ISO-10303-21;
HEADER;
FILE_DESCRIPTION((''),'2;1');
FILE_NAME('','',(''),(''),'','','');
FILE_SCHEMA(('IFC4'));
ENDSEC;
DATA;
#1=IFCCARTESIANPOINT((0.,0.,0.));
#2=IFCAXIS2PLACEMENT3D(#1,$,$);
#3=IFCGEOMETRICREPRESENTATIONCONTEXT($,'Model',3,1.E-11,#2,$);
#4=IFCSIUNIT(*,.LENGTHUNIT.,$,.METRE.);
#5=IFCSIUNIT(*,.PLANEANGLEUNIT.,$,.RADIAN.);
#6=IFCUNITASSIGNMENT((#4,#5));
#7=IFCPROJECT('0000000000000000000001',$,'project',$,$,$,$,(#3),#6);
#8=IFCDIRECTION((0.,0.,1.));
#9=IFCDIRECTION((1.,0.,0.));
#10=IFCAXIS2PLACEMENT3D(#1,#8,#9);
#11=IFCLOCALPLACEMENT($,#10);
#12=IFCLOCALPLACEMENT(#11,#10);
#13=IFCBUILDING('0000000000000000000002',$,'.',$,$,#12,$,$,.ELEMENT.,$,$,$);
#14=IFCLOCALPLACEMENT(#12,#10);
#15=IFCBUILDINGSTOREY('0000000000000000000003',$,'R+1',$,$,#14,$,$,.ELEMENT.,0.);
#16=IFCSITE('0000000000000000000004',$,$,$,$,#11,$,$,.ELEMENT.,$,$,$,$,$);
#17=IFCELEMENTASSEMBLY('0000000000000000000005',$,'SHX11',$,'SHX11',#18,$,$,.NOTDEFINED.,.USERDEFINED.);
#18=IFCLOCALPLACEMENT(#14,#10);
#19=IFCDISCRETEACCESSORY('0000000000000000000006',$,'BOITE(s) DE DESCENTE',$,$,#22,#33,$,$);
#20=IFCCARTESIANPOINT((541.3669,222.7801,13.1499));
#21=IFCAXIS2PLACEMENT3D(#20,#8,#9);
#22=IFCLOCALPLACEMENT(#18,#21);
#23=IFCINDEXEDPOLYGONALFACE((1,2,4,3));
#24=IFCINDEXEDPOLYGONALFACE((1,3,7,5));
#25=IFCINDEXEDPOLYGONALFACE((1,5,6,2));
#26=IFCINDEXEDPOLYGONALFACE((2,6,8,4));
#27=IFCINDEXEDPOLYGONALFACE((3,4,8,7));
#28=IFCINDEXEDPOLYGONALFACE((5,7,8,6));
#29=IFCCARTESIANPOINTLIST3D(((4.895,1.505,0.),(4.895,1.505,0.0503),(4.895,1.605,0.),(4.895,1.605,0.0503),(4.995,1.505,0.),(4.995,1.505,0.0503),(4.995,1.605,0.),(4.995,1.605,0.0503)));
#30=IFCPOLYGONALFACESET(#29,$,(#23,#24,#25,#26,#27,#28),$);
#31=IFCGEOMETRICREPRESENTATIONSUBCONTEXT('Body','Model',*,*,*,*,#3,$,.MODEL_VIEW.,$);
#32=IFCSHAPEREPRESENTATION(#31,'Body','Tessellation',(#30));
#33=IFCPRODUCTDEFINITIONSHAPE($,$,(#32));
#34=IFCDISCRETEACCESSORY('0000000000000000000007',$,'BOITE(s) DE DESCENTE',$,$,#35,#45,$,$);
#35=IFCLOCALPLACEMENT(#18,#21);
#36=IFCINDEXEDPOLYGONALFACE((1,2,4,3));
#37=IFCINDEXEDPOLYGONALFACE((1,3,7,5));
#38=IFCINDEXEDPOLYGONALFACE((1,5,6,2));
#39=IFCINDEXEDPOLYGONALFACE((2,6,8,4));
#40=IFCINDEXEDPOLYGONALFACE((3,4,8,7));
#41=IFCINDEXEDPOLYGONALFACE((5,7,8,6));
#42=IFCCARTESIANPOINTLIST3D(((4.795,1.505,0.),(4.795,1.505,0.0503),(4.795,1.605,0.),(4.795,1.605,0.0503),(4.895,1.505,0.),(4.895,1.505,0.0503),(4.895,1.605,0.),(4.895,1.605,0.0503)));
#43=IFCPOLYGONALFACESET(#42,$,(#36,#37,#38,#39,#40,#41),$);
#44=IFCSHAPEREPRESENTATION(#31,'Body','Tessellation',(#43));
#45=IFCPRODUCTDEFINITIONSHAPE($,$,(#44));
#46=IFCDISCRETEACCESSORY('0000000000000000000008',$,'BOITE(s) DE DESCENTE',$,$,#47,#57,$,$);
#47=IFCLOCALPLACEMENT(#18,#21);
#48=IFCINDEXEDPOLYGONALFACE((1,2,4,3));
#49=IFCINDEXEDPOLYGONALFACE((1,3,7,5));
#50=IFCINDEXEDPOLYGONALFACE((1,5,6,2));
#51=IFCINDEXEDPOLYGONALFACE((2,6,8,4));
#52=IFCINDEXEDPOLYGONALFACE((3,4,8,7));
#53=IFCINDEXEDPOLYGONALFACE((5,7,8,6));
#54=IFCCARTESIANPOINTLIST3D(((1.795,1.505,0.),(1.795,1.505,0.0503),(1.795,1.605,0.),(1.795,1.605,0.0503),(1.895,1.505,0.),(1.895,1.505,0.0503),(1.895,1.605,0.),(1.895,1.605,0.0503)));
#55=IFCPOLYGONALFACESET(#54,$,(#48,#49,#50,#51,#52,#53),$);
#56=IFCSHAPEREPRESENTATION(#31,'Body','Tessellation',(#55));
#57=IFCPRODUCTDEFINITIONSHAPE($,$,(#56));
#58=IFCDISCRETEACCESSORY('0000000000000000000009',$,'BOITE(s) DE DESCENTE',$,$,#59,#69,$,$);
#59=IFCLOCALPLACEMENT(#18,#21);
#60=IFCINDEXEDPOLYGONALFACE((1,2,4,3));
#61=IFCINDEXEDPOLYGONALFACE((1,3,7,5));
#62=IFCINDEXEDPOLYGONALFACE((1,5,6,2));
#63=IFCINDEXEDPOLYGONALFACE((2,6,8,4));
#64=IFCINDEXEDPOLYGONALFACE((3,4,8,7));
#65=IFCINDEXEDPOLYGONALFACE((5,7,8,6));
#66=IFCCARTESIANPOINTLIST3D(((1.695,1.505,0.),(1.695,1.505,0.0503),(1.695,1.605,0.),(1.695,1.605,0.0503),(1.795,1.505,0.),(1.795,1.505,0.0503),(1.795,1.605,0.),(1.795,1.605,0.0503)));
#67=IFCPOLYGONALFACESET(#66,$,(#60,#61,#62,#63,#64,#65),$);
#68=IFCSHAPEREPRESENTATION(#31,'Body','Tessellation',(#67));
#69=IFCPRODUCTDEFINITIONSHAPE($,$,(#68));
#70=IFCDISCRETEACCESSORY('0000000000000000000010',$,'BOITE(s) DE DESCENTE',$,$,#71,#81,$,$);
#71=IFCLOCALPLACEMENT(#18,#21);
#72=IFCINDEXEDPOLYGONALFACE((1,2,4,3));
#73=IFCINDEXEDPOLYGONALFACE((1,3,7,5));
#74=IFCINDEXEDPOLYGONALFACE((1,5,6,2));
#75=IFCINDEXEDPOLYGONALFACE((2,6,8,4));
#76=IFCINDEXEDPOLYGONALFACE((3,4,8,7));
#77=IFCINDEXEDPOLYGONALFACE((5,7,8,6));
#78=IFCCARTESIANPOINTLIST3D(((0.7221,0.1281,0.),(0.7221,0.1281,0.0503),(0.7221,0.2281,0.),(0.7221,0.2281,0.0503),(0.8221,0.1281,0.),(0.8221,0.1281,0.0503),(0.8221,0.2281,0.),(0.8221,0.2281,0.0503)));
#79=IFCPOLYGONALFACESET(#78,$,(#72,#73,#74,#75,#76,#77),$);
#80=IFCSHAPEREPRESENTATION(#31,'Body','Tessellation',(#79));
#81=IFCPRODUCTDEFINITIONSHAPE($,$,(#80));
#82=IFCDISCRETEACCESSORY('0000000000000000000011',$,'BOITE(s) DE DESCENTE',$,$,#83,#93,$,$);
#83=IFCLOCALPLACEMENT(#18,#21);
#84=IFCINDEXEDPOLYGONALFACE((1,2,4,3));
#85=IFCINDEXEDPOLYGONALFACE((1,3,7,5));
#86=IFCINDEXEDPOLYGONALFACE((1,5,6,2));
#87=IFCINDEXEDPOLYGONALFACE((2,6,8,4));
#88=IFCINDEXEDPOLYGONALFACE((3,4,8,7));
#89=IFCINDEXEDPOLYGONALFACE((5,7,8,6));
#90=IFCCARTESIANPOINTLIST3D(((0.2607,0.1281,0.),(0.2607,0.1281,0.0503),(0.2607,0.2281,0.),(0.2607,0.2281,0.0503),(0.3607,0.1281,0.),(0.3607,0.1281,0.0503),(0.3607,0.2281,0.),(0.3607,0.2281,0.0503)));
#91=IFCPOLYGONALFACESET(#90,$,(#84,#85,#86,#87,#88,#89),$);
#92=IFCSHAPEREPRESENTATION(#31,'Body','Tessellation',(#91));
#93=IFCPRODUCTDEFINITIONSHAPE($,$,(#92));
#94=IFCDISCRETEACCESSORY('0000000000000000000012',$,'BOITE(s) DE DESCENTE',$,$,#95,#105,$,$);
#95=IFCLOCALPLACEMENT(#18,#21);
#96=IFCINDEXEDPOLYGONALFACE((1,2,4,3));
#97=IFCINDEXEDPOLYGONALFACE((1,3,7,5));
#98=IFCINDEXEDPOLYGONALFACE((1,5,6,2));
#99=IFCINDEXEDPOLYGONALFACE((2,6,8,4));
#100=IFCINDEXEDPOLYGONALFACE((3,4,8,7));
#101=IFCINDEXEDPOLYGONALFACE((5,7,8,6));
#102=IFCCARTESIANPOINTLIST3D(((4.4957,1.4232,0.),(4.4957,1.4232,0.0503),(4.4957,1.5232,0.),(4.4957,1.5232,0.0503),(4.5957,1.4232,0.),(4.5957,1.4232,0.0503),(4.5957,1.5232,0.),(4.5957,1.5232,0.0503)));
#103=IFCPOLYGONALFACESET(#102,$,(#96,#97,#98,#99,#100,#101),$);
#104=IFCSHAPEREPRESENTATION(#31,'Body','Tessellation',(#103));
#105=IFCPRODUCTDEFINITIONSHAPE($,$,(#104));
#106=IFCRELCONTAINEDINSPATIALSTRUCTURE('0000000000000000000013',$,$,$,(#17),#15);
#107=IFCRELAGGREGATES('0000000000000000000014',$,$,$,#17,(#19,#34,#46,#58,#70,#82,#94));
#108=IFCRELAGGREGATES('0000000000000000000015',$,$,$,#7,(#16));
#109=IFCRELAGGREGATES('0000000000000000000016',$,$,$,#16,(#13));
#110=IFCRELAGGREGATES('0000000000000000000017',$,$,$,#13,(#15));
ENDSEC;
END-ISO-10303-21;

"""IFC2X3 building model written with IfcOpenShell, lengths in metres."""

from ifc_helpers import new_model, si_unit, frame, origin, origin_with_axes, place, context, subcontext, project, spatial, polyline, outline, extrude, element, aggregate, save


model = new_model("IFC2X3")

# Units and contexts
model_context = context("Model", 3, precision=1e-11, world=origin())
body_context = subcontext(model_context, "Body", "Model", "MODEL_VIEW")
ifc_project = project(units=[si_unit("LENGTHUNIT", "METRE"), si_unit("PLANEANGLEUNIT", "RADIAN")], contexts=[model_context])

# Site, building, storey
site_placement = place(None, origin_with_axes())
site = spatial("IfcSite", under=ifc_project, at=site_placement, CompositionType="ELEMENT")
building_placement = place(site_placement, origin_with_axes())
building = spatial("IfcBuilding", under=site, at=building_placement, Name=".", CompositionType="ELEMENT")
storey_placement = place(building_placement, origin_with_axes())
storey = spatial("IfcBuildingStorey", under=building, at=storey_placement, Name="R+1", CompositionType="ELEMENT", Elevation=0.0)

# Element assembly, discrete accessories
assembly_placement = place(storey_placement, origin_with_axes())
assembly = element("IfcElementAssembly", 1, at=assembly_placement, inside=storey, Name="SHX11", ObjectType="SHX11", AssemblyPlace="NOTDEFINED", PredefinedType="USERDEFINED")
discrete_accessory_1_placement = place(assembly_placement, frame((541.3669, 222.7801, 13.1499), z_axis=(0.0, 0.0, 1.0), x_axis=(1.0, 0.0, 0.0)))
discrete_accessory_1 = element("IfcDiscreteAccessory", 2, at=discrete_accessory_1_placement, Name="BOITE(s) DE DESCENTE", context=body_context, shape_type="SweptSolid", body=[
    extrude(outline(polyline([(1.505, -4.895), (1.505, -4.995), (1.605, -4.995), (1.605, -4.895), (1.505, -4.895)])), frame((0.0, 0.0, 0.0), z_axis=(0.0, 0.0, 1.0), x_axis=(0.0, 1.0, 0.0)), (0.0, 0.0, 1.0), 0.0503),
])
discrete_accessory_2_placement = place(assembly_placement, frame((541.3669, 222.7801, 13.1499), z_axis=(0.0, 0.0, 1.0), x_axis=(1.0, 0.0, 0.0)))
discrete_accessory_2 = element("IfcDiscreteAccessory", 3, at=discrete_accessory_2_placement, Name="BOITE(s) DE DESCENTE", context=body_context, shape_type="SweptSolid", body=[
    extrude(outline(polyline([(1.505, -4.795), (1.505, -4.895), (1.605, -4.895), (1.605, -4.795), (1.505, -4.795)])), frame((0.0, 0.0, 0.0), z_axis=(0.0, 0.0, 1.0), x_axis=(0.0, 1.0, 0.0)), (0.0, 0.0, 1.0), 0.0503),
])
discrete_accessory_3_placement = place(assembly_placement, frame((541.3669, 222.7801, 13.1499), z_axis=(0.0, 0.0, 1.0), x_axis=(1.0, 0.0, 0.0)))
discrete_accessory_3 = element("IfcDiscreteAccessory", 4, at=discrete_accessory_3_placement, Name="BOITE(s) DE DESCENTE", context=body_context, shape_type="SweptSolid", body=[
    extrude(outline(polyline([(1.505, -1.795), (1.505, -1.895), (1.605, -1.895), (1.605, -1.795), (1.505, -1.795)])), frame((0.0, 0.0, 0.0), z_axis=(0.0, 0.0, 1.0), x_axis=(0.0, 1.0, 0.0)), (0.0, 0.0, 1.0), 0.0503),
])
discrete_accessory_4_placement = place(assembly_placement, frame((541.3669, 222.7801, 13.1499), z_axis=(0.0, 0.0, 1.0), x_axis=(1.0, 0.0, 0.0)))
discrete_accessory_4 = element("IfcDiscreteAccessory", 5, at=discrete_accessory_4_placement, Name="BOITE(s) DE DESCENTE", context=body_context, shape_type="SweptSolid", body=[
    extrude(outline(polyline([(1.505, -1.695), (1.505, -1.795), (1.605, -1.795), (1.605, -1.695), (1.505, -1.695)])), frame((0.0, 0.0, 0.0), z_axis=(0.0, 0.0, 1.0), x_axis=(0.0, 1.0, 0.0)), (0.0, 0.0, 1.0), 0.0503),
])
discrete_accessory_5_placement = place(assembly_placement, frame((541.3669, 222.7801, 13.1499), z_axis=(0.0, 0.0, 1.0), x_axis=(1.0, 0.0, 0.0)))
discrete_accessory_5 = element("IfcDiscreteAccessory", 6, at=discrete_accessory_5_placement, Name="BOITE(s) DE DESCENTE", context=body_context, shape_type="SweptSolid", body=[
    extrude(outline(polyline([(0.1281, -0.7221), (0.1281, -0.8221), (0.2281, -0.8221), (0.2281, -0.7221), (0.1281, -0.7221)])), frame((0.0, 0.0, 0.0), z_axis=(0.0, 0.0, 1.0), x_axis=(0.0, 1.0, 0.0)), (0.0, 0.0, 1.0), 0.0503),
])
discrete_accessory_6_placement = place(assembly_placement, frame((541.3669, 222.7801, 13.1499), z_axis=(0.0, 0.0, 1.0), x_axis=(1.0, 0.0, 0.0)))
discrete_accessory_6 = element("IfcDiscreteAccessory", 7, at=discrete_accessory_6_placement, Name="BOITE(s) DE DESCENTE", context=body_context, shape_type="SweptSolid", body=[
    extrude(outline(polyline([(0.1281, -0.2607), (0.1281, -0.3607), (0.2281, -0.3607), (0.2281, -0.2607), (0.1281, -0.2607)])), frame((0.0, 0.0, 0.0), z_axis=(0.0, 0.0, 1.0), x_axis=(0.0, 1.0, 0.0)), (0.0, 0.0, 1.0), 0.0503),
])
discrete_accessory_7_placement = place(assembly_placement, frame((541.3669, 222.7801, 13.1499), z_axis=(0.0, 0.0, 1.0), x_axis=(1.0, 0.0, 0.0)))
discrete_accessory_7 = element("IfcDiscreteAccessory", 8, at=discrete_accessory_7_placement, Name="BOITE(s) DE DESCENTE", context=body_context, shape_type="SweptSolid", body=[
    extrude(outline(polyline([(1.4232, -4.4957), (1.4232, -4.5957), (1.5232, -4.5957), (1.5232, -4.4957), (1.4232, -4.4957)])), frame((0.0, 0.0, 0.0), z_axis=(0.0, 0.0, 1.0), x_axis=(0.0, 1.0, 0.0)), (0.0, 0.0, 1.0), 0.0503),
])
aggregate(assembly, [discrete_accessory_1, discrete_accessory_2, discrete_accessory_3, discrete_accessory_4, discrete_accessory_5, discrete_accessory_6, discrete_accessory_7])

save(model, "model.ifc")
